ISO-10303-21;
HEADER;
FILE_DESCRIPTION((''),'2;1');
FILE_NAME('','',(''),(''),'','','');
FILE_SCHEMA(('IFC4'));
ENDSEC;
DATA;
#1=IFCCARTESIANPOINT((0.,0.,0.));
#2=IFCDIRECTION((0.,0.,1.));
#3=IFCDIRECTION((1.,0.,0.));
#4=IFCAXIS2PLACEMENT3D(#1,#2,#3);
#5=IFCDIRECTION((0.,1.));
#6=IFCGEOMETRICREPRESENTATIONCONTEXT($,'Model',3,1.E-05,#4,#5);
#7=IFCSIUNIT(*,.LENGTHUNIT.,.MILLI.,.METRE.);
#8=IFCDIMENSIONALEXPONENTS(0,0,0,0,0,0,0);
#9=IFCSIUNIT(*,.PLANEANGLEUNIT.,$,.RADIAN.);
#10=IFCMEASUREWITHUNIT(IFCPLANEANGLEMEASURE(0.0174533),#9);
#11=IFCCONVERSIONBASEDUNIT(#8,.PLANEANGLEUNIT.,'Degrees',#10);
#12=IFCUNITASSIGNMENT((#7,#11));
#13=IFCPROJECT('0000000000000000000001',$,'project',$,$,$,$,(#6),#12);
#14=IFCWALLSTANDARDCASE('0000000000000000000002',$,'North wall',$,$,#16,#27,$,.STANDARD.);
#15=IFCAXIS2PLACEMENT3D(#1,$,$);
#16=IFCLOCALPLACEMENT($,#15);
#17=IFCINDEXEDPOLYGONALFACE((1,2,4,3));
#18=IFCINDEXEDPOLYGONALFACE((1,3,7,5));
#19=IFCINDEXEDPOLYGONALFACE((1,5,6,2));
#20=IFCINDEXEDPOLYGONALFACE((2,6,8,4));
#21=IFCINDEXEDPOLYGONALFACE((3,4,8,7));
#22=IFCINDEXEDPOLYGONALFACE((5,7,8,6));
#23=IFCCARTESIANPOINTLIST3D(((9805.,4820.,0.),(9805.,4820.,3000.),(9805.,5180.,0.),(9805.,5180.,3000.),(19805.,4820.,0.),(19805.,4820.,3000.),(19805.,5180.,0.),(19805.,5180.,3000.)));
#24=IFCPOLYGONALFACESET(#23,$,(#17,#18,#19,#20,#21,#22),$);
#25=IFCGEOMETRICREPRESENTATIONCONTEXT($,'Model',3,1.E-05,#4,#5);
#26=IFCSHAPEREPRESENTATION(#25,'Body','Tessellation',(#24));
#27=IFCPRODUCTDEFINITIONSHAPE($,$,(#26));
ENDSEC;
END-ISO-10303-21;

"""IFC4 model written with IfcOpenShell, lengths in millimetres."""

from ifc_helpers import new_model, entity, si_unit, converted_unit, direction, frame, origin_with_axes, place, context, project, polyline, outline, extrude, element, save


model = new_model("IFC4")

# Units and contexts
model_context_1 = context("Model", 3, precision=1e-05, world=origin_with_axes(), true_north=direction((0.0, 1.0)))
model_context_2 = context("Model", 3, precision=1e-05, world=origin_with_axes(), true_north=direction((0.0, 1.0)))
ifc_project = project(units=[si_unit("LENGTHUNIT", "METRE", prefix="MILLI"), converted_unit("PLANEANGLEUNIT", "Degrees", entity("IfcPlaneAngleMeasure", 0.0174533), si_unit("PLANEANGLEUNIT", "RADIAN"), dimensions=[0, 0, 0, 0, 0, 0, 0])], contexts=[model_context_1])

# Shared definitions
placement_1 = place(None, frame((14805.0, 0.0, 0.0)))

# Wall
wall_1_placement = place(placement_1, frame((0.0, 5000.0, 0.0), z_axis=(0.0, 0.0, 1.0), x_axis=(1.0, 0.0, 0.0)))
element("IfcWallStandardCase", 1, at=wall_1_placement, Name="North wall", PredefinedType="STANDARD", context=model_context_2, shape_type="SweptSolid", body=[
    extrude(outline(polyline([(-5000.0, -180.0), (5000.0, -180.0), (5000.0, 180.0), (-5000.0, 180.0), (-5000.0, -180.0), (-5000.0, -180.0)])), origin_with_axes(), (0.0, 0.0, 1.0), 3000.0),
])

save(model, "model.ifc")
